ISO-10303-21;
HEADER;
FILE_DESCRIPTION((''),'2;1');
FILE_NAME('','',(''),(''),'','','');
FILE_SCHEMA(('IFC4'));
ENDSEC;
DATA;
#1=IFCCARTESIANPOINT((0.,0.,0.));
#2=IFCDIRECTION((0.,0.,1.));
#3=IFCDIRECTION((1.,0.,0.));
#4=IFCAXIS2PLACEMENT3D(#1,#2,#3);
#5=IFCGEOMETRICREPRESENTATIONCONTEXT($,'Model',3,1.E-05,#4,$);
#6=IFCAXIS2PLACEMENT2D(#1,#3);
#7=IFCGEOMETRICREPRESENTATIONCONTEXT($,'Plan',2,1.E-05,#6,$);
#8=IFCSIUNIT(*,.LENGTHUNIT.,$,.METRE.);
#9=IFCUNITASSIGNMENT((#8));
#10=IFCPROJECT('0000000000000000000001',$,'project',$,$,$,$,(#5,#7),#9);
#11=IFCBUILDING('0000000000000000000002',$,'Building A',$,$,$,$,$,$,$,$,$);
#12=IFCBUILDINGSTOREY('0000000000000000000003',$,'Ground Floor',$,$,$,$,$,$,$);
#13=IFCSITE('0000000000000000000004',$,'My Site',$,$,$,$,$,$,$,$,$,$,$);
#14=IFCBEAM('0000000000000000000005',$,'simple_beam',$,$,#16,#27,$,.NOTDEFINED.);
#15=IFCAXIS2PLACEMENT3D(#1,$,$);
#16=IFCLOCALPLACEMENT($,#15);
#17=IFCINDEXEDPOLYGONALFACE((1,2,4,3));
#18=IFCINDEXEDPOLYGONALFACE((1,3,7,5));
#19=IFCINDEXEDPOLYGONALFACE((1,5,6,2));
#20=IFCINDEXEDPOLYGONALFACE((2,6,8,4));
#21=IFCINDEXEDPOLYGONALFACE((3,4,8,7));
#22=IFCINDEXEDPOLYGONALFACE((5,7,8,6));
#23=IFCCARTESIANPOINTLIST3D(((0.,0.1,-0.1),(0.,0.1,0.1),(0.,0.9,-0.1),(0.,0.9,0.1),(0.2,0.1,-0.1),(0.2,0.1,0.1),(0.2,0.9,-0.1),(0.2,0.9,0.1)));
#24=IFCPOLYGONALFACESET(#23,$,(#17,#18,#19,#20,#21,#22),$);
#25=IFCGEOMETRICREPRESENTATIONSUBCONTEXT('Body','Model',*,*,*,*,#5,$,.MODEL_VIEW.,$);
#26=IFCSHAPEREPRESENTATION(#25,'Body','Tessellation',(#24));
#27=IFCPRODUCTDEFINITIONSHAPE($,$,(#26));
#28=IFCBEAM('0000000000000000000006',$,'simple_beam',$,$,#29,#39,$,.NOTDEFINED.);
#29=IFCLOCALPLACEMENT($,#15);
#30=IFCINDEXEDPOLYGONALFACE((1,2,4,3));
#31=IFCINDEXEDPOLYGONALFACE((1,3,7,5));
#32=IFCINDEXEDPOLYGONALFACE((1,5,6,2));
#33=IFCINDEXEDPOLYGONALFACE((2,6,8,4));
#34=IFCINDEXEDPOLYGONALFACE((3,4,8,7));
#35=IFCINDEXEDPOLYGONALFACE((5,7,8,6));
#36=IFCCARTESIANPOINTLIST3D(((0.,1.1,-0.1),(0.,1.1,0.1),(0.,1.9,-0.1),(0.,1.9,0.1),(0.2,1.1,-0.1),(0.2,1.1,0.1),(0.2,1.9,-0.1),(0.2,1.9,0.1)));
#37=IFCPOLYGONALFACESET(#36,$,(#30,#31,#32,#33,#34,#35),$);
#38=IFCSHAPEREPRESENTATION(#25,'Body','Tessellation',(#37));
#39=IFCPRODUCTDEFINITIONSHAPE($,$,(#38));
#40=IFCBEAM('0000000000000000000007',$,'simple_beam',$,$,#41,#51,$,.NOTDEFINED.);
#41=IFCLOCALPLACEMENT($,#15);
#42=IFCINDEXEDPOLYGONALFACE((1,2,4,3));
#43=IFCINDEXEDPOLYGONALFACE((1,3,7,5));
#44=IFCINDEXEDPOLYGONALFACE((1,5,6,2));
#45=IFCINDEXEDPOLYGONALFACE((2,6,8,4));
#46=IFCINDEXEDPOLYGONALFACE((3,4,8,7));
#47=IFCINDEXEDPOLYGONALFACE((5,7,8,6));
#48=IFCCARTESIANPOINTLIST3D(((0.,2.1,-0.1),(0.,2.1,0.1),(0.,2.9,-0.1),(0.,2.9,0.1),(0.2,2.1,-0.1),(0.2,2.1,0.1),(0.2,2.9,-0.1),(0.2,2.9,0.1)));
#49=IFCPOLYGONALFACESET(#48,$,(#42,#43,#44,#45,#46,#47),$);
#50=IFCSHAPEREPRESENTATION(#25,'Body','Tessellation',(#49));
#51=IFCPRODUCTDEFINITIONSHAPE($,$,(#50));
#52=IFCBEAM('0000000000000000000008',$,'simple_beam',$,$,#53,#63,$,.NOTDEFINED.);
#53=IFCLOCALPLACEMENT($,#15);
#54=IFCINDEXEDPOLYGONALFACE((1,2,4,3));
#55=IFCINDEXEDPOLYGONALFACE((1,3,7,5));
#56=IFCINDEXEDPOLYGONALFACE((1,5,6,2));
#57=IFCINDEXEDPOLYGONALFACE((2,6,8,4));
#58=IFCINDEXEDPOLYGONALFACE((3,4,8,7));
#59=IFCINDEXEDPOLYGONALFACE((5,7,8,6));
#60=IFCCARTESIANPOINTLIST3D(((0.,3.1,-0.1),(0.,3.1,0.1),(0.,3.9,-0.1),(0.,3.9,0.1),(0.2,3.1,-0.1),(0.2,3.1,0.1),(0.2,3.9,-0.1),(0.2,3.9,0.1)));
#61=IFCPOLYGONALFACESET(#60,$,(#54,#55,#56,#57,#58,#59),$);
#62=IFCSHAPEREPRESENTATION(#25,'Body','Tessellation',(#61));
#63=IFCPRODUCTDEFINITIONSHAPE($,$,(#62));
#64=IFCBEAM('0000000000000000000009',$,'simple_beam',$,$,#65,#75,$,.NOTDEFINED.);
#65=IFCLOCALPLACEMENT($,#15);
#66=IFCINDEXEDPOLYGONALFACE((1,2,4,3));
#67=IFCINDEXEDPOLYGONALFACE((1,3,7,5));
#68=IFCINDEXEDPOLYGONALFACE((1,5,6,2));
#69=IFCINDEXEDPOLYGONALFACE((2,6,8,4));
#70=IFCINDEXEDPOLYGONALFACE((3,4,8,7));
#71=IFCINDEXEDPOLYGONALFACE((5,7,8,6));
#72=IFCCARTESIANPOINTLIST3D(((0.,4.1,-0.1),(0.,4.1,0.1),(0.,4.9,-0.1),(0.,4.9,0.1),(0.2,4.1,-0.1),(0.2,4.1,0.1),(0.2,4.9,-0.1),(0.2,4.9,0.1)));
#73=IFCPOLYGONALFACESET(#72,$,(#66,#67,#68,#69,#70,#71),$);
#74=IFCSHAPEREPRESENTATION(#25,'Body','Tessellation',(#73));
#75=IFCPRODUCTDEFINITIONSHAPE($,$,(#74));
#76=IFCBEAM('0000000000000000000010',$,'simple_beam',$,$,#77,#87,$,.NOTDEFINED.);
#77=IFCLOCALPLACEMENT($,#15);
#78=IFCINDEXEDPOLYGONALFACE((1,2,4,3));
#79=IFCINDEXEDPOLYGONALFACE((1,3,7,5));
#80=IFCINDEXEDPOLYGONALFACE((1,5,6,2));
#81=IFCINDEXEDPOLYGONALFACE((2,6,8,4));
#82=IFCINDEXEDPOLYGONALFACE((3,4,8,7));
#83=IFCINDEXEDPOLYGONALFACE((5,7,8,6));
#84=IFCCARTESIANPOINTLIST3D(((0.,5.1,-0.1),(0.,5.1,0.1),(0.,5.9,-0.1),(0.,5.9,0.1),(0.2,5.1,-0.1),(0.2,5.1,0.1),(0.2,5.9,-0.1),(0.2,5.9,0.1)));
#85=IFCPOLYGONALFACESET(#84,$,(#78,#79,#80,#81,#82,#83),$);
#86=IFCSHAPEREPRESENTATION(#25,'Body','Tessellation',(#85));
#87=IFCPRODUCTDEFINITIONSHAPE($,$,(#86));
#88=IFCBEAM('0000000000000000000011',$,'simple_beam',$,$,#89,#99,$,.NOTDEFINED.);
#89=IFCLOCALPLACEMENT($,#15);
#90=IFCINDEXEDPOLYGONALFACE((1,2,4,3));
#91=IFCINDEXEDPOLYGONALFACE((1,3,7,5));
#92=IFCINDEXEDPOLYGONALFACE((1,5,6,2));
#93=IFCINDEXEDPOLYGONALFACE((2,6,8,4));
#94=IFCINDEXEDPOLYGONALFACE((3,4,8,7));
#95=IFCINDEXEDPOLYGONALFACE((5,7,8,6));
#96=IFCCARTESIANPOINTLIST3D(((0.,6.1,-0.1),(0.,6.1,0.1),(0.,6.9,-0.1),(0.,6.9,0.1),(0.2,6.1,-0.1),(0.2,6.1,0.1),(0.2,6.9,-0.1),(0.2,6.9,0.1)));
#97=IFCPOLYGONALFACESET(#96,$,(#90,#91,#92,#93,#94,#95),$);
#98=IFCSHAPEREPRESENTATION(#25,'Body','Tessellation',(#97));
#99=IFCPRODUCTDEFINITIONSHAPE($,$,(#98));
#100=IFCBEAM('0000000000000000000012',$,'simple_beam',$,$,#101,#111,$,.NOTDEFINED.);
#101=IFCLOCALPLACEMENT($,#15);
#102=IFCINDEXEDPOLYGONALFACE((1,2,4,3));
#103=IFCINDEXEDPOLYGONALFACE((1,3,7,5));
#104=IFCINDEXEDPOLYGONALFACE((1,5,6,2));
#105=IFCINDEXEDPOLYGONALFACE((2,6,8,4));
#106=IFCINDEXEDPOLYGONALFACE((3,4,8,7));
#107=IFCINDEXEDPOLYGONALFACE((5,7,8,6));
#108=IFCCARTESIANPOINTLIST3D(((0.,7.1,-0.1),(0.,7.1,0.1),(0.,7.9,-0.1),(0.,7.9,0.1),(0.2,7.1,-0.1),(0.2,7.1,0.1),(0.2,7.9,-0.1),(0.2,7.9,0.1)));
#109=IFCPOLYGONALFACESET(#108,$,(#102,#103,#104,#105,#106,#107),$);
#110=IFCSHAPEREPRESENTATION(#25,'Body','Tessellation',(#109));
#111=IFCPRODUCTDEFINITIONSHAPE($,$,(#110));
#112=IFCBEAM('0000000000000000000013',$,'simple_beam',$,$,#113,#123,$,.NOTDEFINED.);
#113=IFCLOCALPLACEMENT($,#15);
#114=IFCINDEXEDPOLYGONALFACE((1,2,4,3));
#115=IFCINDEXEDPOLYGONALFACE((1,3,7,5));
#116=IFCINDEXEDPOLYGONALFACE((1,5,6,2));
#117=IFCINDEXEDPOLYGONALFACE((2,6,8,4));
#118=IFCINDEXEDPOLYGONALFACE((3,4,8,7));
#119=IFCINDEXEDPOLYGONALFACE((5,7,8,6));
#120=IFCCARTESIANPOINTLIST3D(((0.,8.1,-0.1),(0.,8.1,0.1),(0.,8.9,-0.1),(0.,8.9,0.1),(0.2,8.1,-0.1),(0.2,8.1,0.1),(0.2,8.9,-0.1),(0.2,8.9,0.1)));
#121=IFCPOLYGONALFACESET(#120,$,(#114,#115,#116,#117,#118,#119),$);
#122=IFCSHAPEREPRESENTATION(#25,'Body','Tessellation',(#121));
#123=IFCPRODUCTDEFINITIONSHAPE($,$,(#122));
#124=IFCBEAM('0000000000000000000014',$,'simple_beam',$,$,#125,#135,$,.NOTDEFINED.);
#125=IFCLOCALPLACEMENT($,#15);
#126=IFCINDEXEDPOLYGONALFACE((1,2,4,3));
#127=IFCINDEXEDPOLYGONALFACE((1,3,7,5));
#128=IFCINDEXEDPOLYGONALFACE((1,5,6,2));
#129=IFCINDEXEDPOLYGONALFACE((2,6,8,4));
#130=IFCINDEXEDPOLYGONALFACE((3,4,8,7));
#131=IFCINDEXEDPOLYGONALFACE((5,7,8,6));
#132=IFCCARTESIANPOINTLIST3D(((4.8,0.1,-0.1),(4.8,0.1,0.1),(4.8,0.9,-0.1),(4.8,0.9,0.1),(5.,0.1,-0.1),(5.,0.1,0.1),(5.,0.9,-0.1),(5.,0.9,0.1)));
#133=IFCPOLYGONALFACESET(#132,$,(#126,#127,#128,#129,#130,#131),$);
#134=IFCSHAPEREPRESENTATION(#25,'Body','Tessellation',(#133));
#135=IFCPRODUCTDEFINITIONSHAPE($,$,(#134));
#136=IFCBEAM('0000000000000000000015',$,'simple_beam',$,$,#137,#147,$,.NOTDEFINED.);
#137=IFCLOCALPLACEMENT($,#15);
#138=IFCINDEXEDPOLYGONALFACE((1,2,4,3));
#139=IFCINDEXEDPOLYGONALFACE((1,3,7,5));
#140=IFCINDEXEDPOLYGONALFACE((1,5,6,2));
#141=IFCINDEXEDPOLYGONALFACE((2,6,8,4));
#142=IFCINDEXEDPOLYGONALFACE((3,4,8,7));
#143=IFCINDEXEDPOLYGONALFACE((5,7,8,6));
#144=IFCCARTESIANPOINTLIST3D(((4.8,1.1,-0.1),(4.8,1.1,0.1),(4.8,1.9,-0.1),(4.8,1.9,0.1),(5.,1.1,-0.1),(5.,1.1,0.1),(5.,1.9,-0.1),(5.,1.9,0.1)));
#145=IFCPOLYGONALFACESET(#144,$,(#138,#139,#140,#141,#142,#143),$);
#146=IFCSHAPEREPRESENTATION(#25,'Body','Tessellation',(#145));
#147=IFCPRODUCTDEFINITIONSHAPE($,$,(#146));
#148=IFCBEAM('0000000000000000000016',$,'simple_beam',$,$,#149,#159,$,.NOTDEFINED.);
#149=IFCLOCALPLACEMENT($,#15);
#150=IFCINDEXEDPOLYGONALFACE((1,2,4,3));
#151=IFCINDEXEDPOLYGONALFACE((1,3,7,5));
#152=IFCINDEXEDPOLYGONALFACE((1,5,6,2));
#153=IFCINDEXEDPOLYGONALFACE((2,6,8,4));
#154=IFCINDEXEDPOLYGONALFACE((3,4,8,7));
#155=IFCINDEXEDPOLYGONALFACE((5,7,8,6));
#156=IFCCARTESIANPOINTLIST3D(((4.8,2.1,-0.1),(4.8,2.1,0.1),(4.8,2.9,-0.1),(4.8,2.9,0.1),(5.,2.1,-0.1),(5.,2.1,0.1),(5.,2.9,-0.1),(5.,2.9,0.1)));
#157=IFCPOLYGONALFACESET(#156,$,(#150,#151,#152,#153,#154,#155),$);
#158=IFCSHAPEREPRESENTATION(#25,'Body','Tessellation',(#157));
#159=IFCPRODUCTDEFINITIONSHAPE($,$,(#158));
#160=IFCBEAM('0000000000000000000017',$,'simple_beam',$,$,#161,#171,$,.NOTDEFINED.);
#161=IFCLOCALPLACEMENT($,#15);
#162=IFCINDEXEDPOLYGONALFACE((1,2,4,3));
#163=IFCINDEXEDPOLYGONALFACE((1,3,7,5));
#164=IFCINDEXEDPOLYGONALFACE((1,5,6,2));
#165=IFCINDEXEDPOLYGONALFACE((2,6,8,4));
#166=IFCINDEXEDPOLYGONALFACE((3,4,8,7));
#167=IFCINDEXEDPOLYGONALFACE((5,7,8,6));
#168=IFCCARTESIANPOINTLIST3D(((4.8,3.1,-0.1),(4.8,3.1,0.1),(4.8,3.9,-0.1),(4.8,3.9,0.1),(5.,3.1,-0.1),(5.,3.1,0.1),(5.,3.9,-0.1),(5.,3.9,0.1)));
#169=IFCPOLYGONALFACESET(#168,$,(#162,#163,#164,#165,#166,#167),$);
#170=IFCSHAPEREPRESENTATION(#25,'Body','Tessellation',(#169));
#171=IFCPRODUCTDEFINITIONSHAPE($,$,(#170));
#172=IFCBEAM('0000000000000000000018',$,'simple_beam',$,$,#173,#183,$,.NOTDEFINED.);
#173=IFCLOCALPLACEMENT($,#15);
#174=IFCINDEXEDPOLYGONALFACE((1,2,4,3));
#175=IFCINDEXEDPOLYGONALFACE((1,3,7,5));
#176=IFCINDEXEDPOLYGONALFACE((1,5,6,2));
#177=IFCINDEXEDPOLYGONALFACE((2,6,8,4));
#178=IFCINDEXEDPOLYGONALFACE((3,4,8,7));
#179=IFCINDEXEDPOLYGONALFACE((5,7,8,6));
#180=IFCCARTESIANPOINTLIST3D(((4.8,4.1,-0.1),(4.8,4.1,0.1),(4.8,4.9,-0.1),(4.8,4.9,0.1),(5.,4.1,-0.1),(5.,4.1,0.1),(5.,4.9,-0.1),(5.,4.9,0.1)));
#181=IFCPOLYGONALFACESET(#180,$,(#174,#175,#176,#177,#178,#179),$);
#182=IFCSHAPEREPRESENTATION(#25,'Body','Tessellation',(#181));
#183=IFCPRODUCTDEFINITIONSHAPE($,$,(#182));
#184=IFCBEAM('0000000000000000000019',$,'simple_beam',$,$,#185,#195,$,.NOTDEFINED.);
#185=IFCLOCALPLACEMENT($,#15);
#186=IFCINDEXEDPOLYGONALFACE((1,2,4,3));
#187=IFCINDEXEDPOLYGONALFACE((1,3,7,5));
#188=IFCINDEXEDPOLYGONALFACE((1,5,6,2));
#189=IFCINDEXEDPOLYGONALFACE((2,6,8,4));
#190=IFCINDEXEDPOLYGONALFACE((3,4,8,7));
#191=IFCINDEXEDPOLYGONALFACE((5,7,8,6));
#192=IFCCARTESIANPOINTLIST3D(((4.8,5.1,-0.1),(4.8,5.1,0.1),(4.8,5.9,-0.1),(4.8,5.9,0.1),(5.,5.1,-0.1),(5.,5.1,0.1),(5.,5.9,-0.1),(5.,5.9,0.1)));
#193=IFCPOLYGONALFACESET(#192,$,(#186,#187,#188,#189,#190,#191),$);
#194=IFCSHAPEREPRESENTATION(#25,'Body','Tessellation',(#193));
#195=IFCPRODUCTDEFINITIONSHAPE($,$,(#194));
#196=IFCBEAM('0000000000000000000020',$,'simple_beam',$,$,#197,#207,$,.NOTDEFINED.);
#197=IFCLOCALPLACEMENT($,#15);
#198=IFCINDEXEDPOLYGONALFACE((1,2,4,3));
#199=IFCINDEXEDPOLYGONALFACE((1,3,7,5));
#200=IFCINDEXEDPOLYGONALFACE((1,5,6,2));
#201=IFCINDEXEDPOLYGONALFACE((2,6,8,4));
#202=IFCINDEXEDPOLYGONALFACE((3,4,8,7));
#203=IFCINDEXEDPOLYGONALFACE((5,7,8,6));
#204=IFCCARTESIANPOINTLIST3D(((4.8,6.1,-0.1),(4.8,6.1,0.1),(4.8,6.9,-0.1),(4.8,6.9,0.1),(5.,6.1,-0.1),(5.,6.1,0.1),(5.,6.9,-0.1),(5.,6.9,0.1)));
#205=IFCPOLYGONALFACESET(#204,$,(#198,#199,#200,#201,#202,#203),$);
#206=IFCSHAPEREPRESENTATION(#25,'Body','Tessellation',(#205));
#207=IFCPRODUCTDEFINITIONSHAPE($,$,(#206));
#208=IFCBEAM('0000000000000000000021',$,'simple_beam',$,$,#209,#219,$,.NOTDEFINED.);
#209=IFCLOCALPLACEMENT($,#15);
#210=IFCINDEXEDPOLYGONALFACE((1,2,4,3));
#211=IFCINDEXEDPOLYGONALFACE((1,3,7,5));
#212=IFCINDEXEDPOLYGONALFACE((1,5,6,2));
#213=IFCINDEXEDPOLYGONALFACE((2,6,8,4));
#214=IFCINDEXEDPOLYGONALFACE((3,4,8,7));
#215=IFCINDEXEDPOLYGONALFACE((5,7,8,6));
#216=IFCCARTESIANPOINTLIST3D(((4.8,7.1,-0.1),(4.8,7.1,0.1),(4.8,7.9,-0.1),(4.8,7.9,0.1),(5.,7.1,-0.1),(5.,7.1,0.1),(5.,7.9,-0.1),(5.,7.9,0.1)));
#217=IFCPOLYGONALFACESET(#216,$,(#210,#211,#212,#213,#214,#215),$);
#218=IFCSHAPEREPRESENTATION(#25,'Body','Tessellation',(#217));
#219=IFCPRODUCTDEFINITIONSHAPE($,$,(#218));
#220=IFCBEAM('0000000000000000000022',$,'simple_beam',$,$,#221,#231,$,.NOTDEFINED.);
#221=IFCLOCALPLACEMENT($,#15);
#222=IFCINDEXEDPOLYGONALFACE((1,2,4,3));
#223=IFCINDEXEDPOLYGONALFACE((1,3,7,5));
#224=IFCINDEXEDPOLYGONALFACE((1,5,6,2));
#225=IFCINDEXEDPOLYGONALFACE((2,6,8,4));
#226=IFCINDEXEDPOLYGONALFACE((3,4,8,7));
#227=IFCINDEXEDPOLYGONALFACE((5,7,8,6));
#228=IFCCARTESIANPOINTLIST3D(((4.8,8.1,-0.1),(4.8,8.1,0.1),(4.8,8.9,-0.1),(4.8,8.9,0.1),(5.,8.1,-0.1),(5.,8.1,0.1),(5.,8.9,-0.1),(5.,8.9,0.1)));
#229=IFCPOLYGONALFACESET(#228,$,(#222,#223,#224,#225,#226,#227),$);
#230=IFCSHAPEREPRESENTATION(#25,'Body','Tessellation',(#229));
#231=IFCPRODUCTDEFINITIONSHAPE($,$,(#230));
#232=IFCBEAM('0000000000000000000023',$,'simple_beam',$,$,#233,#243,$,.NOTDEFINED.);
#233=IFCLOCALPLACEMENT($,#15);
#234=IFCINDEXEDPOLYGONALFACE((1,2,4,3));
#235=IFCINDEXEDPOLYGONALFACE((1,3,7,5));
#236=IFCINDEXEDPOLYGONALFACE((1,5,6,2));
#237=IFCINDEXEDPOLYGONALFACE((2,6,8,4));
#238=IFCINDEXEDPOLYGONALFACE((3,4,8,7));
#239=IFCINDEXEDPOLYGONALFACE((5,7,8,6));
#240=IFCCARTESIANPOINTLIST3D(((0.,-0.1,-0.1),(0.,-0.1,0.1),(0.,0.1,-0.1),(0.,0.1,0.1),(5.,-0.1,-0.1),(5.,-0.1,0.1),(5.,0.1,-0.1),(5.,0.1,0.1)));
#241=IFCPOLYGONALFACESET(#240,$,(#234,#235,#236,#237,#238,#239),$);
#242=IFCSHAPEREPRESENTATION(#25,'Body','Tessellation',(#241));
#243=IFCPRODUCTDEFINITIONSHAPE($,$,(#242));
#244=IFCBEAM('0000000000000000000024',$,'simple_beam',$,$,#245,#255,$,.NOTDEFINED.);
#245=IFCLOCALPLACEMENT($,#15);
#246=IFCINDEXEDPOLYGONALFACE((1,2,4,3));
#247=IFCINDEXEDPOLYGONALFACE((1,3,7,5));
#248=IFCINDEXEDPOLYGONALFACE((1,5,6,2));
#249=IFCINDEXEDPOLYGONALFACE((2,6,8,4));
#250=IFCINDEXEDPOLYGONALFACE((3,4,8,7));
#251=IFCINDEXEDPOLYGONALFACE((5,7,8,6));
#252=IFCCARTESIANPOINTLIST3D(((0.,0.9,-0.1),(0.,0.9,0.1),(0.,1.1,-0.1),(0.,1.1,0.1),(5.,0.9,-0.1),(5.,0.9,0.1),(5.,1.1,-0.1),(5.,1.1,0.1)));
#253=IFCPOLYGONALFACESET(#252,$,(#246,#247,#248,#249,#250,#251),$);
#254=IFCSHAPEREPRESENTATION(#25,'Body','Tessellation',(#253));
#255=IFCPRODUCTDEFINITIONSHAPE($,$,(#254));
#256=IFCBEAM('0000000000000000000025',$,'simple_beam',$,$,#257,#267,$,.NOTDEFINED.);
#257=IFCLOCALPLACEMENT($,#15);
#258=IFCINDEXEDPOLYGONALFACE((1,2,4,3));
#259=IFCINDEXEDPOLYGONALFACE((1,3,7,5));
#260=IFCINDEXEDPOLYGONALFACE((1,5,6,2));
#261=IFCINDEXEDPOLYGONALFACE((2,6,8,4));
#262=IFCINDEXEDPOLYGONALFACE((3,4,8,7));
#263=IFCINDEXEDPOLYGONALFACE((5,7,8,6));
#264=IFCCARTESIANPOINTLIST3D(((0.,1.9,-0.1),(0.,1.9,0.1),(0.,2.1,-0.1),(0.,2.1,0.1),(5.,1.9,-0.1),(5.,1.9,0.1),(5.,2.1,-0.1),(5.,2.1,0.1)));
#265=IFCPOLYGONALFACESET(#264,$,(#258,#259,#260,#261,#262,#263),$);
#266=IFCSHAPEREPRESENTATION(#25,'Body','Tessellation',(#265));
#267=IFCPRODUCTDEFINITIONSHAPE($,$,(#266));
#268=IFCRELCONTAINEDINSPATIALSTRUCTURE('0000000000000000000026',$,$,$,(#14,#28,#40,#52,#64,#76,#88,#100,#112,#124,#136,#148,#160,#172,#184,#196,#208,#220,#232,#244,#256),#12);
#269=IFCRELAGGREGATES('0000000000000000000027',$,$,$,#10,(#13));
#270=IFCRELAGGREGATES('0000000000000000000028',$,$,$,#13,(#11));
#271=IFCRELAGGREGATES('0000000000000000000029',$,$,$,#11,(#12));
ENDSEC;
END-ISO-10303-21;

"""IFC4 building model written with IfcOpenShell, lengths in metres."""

from ifc_helpers import new_model, si_unit, frame, frame_2d, origin_with_axes, place, context, subcontext, project, spatial, rectangle, extrude, element, save


model = new_model("IFC4")

# Units and contexts
model_context = context("Model", 3, precision=1e-05, world=origin_with_axes())
plan_context = context("Plan", 2, precision=1e-05, world=frame_2d((0.0, 0.0, 0.0), x_axis=(1.0, 0.0, 0.0)))
body_context = subcontext(model_context, "Body", "Model", "MODEL_VIEW")
ifc_project = project(units=[si_unit("LENGTHUNIT", "METRE")], contexts=[model_context, plan_context])

# Site, building, storey
site = spatial("IfcSite", under=ifc_project, Name="My Site")
building = spatial("IfcBuilding", under=site, Name="Building A")
storey = spatial("IfcBuildingStorey", under=building, Name="Ground Floor")

# Beams
for number, where, z_axis, x_axis, name in (
    (1, (0.1, 0.1, 0.0), (0.0, 1.0, 0.0), (0.0, 1.0, 1.0), "simple_beam"),
    (2, (0.1, 1.1, 0.0), (0.0, 1.0, 0.0), (0.0, 1.0, 1.0), "simple_beam"),
    (3, (0.1, 2.1, 0.0), (0.0, 1.0, 0.0), (0.0, 1.0, 1.0), "simple_beam"),
    (4, (0.1, 3.1, 0.0), (0.0, 1.0, 0.0), (0.0, 1.0, 1.0), "simple_beam"),
    (5, (0.1, 4.1, 0.0), (0.0, 1.0, 0.0), (0.0, 1.0, 1.0), "simple_beam"),
    (6, (0.1, 5.1, 0.0), (0.0, 1.0, 0.0), (0.0, 1.0, 1.0), "simple_beam"),
    (7, (0.1, 6.1, 0.0), (0.0, 1.0, 0.0), (0.0, 1.0, 1.0), "simple_beam"),
    (8, (0.1, 7.1, 0.0), (0.0, 1.0, 0.0), (0.0, 1.0, 1.0), "simple_beam"),
    (9, (0.1, 8.1, 0.0), (0.0, 1.0, 0.0), (0.0, 1.0, 1.0), "simple_beam"),
    (10, (4.9, 0.1, 0.0), (0.0, 1.0, 0.0), (0.0, 1.0, 1.0), "simple_beam"),
    (11, (4.9, 1.1, 0.0), (0.0, 1.0, 0.0), (0.0, 1.0, 1.0), "simple_beam"),
    (12, (4.9, 2.1, 0.0), (0.0, 1.0, 0.0), (0.0, 1.0, 1.0), "simple_beam"),
    (13, (4.9, 3.1, 0.0), (0.0, 1.0, 0.0), (0.0, 1.0, 1.0), "simple_beam"),
    (14, (4.9, 4.1, 0.0), (0.0, 1.0, 0.0), (0.0, 1.0, 1.0), "simple_beam"),
    (15, (4.9, 5.1, 0.0), (0.0, 1.0, 0.0), (0.0, 1.0, 1.0), "simple_beam"),
    (16, (4.9, 6.1, 0.0), (0.0, 1.0, 0.0), (0.0, 1.0, 1.0), "simple_beam"),
    (17, (4.9, 7.1, 0.0), (0.0, 1.0, 0.0), (0.0, 1.0, 1.0), "simple_beam"),
    (18, (4.9, 8.1, 0.0), (0.0, 1.0, 0.0), (0.0, 1.0, 1.0), "simple_beam"),
):
    element("IfcBeam", number, at=place(None, frame(where, z_axis=z_axis, x_axis=x_axis)), inside=storey, Name=name, PredefinedType="NOTDEFINED", context=body_context, shape_type="SweptSolid", body=[
        extrude(rectangle(XDim=0.2, YDim=0.2), origin_with_axes(), (0.0, 0.0, 1.0), 0.8),
    ])
for number, where, z_axis, x_axis, name in (
    (19, (0.0, 0.0, 0.0), (1.0, 0.0, 0.0), (0.0, 0.0, 1.0), "simple_beam"),
    (20, (0.0, 1.0, 0.0), (1.0, 0.0, 0.0), (0.0, 0.0, 1.0), "simple_beam"),
    (21, (0.0, 2.0, 0.0), (1.0, 0.0, 0.0), (0.0, 0.0, 1.0), "simple_beam"),
):
    element("IfcBeam", number, at=place(None, frame(where, z_axis=z_axis, x_axis=x_axis)), inside=storey, Name=name, PredefinedType="NOTDEFINED", context=body_context, shape_type="SweptSolid", body=[
        extrude(rectangle(XDim=0.2, YDim=0.2), origin_with_axes(), (0.0, 0.0, 1.0), 5.0),
    ])

save(model, "model.ifc")
